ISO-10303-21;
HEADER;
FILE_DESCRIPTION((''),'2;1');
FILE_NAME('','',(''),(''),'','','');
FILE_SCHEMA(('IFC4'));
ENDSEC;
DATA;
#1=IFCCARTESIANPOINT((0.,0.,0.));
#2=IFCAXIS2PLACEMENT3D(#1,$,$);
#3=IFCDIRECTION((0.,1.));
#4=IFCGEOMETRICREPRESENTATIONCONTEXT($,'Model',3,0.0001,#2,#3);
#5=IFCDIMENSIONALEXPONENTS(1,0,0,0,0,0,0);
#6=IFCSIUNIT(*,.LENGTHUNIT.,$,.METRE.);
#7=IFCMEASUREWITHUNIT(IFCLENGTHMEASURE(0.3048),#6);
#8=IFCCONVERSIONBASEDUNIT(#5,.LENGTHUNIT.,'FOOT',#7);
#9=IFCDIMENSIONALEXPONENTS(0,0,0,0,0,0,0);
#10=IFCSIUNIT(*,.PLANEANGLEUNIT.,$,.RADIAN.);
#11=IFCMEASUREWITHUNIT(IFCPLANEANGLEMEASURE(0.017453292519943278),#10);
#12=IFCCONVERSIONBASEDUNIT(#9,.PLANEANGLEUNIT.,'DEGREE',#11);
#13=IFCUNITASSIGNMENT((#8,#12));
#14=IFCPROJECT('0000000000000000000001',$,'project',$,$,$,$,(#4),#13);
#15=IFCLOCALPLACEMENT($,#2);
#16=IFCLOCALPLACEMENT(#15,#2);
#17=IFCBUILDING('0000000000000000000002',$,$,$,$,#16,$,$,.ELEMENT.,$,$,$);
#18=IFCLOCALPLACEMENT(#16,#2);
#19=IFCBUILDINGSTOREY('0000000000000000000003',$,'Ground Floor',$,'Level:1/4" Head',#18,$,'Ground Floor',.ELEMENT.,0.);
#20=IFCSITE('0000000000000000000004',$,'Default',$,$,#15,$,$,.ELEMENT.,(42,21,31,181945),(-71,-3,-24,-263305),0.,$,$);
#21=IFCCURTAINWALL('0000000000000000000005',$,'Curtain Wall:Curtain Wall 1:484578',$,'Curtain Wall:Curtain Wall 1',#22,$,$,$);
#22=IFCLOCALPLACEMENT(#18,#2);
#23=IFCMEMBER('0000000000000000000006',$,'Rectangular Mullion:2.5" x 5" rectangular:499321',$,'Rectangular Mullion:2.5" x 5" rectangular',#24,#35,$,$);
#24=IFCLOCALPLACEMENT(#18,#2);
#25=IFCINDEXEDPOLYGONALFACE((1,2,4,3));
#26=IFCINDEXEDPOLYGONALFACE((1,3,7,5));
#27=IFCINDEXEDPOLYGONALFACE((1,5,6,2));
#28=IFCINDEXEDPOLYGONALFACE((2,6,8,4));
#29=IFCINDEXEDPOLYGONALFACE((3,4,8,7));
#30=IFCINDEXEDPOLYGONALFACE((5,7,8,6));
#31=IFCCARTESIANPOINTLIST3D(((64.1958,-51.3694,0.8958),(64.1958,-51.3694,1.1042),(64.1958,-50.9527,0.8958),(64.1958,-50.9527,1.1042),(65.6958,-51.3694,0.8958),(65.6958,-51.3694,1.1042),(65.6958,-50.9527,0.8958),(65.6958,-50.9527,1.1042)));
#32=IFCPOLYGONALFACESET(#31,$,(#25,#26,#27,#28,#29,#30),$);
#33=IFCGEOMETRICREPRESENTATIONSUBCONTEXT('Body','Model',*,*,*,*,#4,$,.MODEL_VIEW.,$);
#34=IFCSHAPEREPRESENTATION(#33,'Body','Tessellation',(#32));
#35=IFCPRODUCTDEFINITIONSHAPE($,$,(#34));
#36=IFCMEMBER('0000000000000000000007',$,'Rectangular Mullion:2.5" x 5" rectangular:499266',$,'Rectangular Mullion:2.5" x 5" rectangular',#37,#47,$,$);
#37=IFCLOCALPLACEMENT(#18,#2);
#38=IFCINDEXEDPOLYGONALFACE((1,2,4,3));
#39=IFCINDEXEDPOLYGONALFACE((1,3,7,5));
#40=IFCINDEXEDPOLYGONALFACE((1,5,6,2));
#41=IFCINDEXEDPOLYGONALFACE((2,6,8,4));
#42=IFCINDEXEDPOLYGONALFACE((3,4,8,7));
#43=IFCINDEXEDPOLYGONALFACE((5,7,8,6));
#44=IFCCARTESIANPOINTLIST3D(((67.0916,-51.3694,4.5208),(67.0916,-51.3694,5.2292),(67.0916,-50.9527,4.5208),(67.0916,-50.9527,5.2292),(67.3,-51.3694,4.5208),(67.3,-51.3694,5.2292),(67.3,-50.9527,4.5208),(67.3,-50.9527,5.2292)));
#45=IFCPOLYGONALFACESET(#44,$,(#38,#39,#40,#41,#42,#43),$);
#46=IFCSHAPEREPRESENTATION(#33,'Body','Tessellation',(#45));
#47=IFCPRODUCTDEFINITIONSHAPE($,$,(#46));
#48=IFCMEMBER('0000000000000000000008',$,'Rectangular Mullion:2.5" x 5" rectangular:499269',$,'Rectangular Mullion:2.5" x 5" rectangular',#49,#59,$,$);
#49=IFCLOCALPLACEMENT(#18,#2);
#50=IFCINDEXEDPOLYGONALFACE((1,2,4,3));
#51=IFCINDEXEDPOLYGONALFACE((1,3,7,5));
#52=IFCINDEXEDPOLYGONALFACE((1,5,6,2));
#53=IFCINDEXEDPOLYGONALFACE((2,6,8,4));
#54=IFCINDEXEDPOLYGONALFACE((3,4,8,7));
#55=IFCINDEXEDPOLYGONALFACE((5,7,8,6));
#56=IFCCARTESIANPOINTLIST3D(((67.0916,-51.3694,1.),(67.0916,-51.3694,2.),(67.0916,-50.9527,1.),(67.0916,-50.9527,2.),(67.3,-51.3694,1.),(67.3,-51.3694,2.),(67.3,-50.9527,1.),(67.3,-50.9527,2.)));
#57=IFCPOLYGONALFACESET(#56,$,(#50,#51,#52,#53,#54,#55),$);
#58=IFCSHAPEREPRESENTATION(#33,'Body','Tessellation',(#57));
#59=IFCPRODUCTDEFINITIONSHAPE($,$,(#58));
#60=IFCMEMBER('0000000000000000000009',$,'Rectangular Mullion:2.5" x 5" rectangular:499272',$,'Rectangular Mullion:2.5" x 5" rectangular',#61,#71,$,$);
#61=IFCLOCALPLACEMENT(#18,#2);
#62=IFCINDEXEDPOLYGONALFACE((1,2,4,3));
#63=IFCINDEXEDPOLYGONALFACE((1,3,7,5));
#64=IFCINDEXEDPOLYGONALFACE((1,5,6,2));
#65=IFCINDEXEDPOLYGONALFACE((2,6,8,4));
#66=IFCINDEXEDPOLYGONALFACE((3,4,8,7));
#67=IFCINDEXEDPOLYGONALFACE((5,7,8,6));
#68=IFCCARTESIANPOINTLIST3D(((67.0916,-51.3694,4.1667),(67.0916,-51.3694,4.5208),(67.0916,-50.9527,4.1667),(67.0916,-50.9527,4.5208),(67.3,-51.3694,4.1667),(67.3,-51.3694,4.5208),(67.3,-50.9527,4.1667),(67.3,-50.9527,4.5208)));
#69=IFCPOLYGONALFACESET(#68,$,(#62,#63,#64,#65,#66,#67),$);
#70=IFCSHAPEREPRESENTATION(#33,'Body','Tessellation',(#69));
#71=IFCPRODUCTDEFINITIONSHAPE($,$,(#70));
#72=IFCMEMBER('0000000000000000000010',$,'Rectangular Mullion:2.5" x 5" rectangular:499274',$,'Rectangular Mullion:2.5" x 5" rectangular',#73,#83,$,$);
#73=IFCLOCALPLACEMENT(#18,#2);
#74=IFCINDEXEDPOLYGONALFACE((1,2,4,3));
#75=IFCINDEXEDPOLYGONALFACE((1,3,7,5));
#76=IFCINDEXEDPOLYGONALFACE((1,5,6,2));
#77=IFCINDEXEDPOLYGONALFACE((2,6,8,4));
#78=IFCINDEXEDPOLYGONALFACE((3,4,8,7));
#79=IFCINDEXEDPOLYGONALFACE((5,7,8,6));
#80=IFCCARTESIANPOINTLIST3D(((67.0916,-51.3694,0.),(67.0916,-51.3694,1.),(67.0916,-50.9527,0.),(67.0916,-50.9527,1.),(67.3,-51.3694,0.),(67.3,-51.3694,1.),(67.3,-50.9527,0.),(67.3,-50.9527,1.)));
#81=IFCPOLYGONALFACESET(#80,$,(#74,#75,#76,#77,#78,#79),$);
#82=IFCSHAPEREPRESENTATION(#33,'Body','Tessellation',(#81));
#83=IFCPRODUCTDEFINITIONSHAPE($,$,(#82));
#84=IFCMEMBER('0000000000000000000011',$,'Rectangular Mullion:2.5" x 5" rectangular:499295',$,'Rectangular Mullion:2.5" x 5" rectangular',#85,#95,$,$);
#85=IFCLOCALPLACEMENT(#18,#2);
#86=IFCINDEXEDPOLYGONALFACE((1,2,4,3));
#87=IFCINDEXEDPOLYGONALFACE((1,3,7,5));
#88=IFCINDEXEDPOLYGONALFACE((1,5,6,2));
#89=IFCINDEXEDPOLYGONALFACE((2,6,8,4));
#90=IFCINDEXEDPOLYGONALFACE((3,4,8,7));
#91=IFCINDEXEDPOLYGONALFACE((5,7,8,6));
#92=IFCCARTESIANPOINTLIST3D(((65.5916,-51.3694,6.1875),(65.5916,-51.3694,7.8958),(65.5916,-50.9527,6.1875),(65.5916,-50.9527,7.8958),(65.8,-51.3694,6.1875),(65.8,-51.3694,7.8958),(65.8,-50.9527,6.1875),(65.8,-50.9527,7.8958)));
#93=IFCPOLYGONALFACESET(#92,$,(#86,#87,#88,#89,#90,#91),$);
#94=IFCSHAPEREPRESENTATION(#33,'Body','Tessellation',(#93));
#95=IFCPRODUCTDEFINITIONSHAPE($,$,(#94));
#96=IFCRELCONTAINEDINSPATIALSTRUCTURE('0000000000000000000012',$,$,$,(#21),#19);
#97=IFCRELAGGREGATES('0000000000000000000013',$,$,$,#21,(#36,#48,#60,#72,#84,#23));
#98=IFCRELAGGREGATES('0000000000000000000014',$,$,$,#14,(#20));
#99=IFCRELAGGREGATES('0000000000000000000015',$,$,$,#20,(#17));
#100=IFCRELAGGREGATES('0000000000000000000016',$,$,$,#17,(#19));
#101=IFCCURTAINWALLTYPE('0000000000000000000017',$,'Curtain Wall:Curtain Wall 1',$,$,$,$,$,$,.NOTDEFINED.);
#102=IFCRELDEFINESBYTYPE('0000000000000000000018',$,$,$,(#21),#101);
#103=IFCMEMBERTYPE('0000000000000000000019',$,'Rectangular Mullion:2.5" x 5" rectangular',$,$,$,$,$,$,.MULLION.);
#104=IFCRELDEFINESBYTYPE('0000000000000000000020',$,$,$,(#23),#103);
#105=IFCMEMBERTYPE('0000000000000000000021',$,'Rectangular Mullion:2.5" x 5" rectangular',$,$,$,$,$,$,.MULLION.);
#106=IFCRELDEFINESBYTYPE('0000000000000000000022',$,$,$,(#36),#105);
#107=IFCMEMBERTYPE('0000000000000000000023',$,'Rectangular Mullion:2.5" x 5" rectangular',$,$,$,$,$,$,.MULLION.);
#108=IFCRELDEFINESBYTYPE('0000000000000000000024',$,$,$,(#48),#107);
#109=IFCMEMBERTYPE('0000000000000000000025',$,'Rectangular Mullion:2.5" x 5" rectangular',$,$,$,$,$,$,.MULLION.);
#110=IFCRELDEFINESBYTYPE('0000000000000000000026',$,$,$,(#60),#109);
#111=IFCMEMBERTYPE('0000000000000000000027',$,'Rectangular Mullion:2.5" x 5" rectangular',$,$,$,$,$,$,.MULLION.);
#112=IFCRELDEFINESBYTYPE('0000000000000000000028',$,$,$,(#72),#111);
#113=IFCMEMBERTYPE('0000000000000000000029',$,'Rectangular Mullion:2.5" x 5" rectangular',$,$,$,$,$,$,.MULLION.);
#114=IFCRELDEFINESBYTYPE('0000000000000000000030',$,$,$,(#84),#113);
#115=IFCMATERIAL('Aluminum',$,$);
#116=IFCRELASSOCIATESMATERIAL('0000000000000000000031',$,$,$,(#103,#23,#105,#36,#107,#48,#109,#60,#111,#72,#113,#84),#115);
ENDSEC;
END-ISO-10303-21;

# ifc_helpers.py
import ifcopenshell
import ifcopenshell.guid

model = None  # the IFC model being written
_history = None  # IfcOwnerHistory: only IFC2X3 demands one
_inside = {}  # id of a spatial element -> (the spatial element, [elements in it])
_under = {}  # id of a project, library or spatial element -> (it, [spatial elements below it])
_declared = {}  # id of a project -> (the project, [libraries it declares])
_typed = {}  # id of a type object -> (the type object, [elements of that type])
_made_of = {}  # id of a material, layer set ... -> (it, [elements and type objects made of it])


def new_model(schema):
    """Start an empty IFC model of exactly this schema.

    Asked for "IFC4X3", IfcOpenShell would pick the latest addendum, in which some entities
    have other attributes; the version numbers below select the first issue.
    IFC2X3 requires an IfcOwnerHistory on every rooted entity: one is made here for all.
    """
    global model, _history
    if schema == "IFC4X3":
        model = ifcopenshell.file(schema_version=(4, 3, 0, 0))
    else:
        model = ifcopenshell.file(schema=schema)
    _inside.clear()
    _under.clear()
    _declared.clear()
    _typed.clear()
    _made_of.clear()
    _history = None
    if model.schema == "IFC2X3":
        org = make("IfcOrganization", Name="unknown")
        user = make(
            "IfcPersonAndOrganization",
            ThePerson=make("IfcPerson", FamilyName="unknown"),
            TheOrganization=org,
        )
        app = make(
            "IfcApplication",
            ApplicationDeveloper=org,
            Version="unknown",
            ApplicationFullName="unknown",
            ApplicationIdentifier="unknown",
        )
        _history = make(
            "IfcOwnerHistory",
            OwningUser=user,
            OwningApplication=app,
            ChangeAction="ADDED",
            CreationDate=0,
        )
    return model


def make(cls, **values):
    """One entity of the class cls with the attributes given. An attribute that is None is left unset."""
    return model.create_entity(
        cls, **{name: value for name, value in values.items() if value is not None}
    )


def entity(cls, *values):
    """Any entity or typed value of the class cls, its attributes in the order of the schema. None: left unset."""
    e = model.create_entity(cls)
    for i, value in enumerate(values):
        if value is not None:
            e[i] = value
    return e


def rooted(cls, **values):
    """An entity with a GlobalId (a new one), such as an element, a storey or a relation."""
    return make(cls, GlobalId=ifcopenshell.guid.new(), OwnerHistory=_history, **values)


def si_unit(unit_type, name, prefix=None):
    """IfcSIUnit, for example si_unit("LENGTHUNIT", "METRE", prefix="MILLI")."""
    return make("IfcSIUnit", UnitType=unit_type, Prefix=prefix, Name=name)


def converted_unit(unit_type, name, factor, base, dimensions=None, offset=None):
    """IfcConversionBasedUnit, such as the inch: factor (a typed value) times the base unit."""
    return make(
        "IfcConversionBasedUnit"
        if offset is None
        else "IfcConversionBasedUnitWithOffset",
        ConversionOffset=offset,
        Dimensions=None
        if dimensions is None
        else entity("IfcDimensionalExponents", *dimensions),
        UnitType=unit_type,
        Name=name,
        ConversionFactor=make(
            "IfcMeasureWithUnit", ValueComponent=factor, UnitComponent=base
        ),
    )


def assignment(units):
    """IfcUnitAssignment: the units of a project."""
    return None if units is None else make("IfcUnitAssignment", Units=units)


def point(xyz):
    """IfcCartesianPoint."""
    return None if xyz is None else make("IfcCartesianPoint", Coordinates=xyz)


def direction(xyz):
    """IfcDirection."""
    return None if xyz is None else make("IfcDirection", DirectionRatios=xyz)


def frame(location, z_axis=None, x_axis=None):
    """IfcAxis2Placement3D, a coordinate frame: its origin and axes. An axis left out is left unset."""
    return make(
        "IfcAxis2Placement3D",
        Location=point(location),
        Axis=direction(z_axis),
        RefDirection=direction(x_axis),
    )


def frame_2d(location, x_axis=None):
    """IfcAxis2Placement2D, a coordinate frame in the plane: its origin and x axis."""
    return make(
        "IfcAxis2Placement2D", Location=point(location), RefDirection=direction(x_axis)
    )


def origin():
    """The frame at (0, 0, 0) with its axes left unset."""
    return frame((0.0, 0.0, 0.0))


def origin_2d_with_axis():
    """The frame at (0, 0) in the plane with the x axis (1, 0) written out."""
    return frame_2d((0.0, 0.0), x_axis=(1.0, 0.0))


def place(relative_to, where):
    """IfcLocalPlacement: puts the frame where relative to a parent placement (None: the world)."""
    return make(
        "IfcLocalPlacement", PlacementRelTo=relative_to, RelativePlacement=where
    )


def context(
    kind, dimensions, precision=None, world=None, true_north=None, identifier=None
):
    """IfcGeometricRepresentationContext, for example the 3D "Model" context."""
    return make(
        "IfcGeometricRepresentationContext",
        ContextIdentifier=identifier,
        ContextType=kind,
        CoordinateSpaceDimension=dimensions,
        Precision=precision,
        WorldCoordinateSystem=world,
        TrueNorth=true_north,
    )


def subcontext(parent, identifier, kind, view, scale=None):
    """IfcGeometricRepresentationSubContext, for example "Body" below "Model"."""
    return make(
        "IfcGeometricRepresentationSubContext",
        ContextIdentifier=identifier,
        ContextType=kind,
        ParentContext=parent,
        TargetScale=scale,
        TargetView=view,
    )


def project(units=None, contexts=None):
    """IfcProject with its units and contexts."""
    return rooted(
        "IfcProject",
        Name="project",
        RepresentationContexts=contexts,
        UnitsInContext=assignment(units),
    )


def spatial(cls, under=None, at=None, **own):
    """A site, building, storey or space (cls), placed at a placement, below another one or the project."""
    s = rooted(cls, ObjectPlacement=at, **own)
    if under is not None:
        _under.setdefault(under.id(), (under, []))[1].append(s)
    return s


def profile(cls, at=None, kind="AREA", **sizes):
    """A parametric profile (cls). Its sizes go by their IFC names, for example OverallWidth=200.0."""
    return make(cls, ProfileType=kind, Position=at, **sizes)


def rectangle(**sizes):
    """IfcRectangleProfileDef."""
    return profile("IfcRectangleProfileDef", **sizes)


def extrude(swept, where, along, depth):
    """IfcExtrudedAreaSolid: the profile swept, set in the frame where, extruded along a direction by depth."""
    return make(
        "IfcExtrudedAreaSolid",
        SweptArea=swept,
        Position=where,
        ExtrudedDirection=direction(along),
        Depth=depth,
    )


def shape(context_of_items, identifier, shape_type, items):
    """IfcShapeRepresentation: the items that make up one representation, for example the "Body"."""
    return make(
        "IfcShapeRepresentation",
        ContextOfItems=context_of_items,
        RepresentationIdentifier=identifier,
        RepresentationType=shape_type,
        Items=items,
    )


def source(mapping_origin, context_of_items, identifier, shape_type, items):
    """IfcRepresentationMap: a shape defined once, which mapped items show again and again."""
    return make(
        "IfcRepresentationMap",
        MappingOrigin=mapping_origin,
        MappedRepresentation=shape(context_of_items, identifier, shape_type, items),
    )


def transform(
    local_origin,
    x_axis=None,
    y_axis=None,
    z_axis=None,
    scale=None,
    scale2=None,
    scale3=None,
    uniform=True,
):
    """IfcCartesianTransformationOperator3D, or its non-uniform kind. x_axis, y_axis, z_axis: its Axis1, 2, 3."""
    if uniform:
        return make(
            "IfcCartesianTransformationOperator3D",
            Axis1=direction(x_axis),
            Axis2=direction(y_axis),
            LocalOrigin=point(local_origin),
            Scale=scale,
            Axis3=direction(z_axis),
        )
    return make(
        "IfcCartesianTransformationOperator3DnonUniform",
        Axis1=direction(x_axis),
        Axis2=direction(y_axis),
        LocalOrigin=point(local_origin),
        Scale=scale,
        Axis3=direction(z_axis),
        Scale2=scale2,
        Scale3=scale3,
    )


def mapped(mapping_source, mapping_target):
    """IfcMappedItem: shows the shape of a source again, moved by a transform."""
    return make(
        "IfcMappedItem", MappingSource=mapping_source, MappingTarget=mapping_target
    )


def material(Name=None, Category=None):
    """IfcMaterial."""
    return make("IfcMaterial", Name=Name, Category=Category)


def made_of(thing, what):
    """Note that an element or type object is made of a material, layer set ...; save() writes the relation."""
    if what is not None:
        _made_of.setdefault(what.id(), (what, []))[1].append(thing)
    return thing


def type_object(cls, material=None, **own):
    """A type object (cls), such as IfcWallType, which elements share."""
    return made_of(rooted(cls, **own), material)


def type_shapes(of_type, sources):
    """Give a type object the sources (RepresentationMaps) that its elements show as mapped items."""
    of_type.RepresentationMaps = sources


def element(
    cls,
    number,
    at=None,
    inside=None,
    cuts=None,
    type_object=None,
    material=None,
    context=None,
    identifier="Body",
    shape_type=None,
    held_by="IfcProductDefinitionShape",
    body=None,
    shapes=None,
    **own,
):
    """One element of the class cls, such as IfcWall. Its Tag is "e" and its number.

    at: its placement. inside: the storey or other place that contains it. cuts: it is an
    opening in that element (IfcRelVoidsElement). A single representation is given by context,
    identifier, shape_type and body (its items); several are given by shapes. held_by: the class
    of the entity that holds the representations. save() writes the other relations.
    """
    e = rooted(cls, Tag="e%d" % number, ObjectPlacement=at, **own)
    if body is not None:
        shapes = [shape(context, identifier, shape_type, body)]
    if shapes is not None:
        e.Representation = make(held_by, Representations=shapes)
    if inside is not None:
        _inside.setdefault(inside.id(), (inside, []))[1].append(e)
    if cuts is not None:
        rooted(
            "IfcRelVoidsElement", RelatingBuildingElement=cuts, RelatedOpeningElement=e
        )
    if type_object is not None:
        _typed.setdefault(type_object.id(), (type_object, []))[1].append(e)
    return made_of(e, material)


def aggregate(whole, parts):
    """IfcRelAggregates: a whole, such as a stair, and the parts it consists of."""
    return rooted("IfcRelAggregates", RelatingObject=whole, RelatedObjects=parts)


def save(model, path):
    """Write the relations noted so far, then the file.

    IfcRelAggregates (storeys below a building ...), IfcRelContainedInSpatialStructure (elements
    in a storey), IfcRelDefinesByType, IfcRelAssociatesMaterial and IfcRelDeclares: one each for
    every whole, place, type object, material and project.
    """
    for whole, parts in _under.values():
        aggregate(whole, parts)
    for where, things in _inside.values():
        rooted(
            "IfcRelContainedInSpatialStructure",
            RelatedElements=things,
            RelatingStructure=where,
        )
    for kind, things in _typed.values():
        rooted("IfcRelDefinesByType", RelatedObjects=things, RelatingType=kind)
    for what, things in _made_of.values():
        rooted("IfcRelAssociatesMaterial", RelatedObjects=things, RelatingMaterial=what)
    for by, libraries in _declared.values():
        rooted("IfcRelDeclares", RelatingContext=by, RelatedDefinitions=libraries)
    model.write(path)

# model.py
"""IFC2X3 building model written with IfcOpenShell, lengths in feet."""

from ifc_helpers import new_model, entity, si_unit, converted_unit, direction, frame, origin, origin_2d_with_axis, place, context, subcontext, project, spatial, rectangle, extrude, source, transform, mapped, material, type_object, type_shapes, element, aggregate, save


model = new_model("IFC2X3")

# Units and contexts
model_context = context("Model", 3, precision=0.0001, world=origin(), true_north=direction((0.0, 1.0)))
body_context = subcontext(model_context, "Body", "Model", "MODEL_VIEW")
ifc_project = project(units=[converted_unit("LENGTHUNIT", "FOOT", entity("IfcLengthMeasure", 0.3048), si_unit("LENGTHUNIT", "METRE"), dimensions=[1, 0, 0, 0, 0, 0, 0]), converted_unit("PLANEANGLEUNIT", "DEGREE", entity("IfcPlaneAngleMeasure", 0.017453292519943278), si_unit("PLANEANGLEUNIT", "RADIAN"), dimensions=[0, 0, 0, 0, 0, 0, 0])], contexts=[model_context])

# Site, building, storey
site_placement = place(None, origin())
site = spatial("IfcSite", under=ifc_project, at=site_placement, Name="Default", CompositionType="ELEMENT", RefLatitude=(42, 21, 31, 181945), RefLongitude=(-71, -3, -24, -263305), RefElevation=0.0)
building_placement = place(site_placement, origin())
building = spatial("IfcBuilding", under=site, at=building_placement, CompositionType="ELEMENT")
storey_placement = place(building_placement, origin())
storey = spatial("IfcBuildingStorey", under=building, at=storey_placement, Name="Ground Floor", ObjectType="Level:1/4\" Head", LongName="Ground Floor", CompositionType="ELEMENT", Elevation=0.0)

# Curtain wall, members
curtain_wall_type = type_object("IfcCurtainWallType", Name="Curtain Wall:Curtain Wall 1", PredefinedType="NOTDEFINED")
curtain_wall_placement = place(storey_placement, origin())
curtain_wall = element("IfcCurtainWall", 1, at=curtain_wall_placement, inside=storey, type_object=curtain_wall_type, Name="Curtain Wall:Curtain Wall 1:484578", ObjectType="Curtain Wall:Curtain Wall 1")
ifc_material_1 = material(Name="Aluminum")
member_type_1 = type_object("IfcMemberType", Name="Rectangular Mullion:2.5\" x 5\" rectangular", PredefinedType="MULLION", material=ifc_material_1)
shared_shape_1 = source(origin(), body_context, "Body", "SweptSolid", [
    extrude(rectangle(XDim=0.2083, YDim=0.4167, at=origin_2d_with_axis()), frame((0.0, 0.0, -1.5), z_axis=(0.0, 0.0, 1.0), x_axis=(-1.0, 0.0, 0.0)), (0.0, 0.0, 1.0), 1.5),
])
type_shapes(member_type_1, [shared_shape_1])
member_1_placement = place(curtain_wall_placement, frame((65.6958, -51.161, 1.0), z_axis=(1.0, 0.0, 0.0), x_axis=(0.0, 0.0, 1.0)))
member_1 = element("IfcMember", 2, at=member_1_placement, type_object=member_type_1, material=ifc_material_1, Name="Rectangular Mullion:2.5\" x 5\" rectangular:499321", ObjectType="Rectangular Mullion:2.5\" x 5\" rectangular", context=body_context, shape_type="MappedRepresentation", body=[
    mapped(shared_shape_1, transform((0.0, 0.0, 0.0), scale=1.0)),
])
member_type_2 = type_object("IfcMemberType", Name="Rectangular Mullion:2.5\" x 5\" rectangular", PredefinedType="MULLION", material=ifc_material_1)
shared_shape_2 = source(origin(), body_context, "Body", "SweptSolid", [
    extrude(rectangle(XDim=0.2083, YDim=0.4167, at=origin_2d_with_axis()), frame((0.0, 0.0, -0.7083), z_axis=(0.0, 0.0, 1.0), x_axis=(-1.0, 0.0, 0.0)), (0.0, 0.0, 1.0), 0.7083),
])
type_shapes(member_type_2, [shared_shape_2])
member_2_placement = place(curtain_wall_placement, frame((67.1958, -51.161, 4.5208), z_axis=(0.0, 0.0, -1.0), x_axis=(1.0, 0.0, 0.0)))
member_2 = element("IfcMember", 3, at=member_2_placement, type_object=member_type_2, material=ifc_material_1, Name="Rectangular Mullion:2.5\" x 5\" rectangular:499266", ObjectType="Rectangular Mullion:2.5\" x 5\" rectangular", context=body_context, shape_type="MappedRepresentation", body=[
    mapped(shared_shape_2, transform((0.0, 0.0, 0.0), scale=1.0)),
])
member_type_3 = type_object("IfcMemberType", Name="Rectangular Mullion:2.5\" x 5\" rectangular", PredefinedType="MULLION", material=ifc_material_1)
shared_shape_3 = source(origin(), body_context, "Body", "SweptSolid", [
    extrude(rectangle(XDim=0.2083, YDim=0.4167, at=origin_2d_with_axis()), frame((0.0, 0.0, -1.0), z_axis=(0.0, 0.0, 1.0), x_axis=(-1.0, 0.0, 0.0)), (0.0, 0.0, 1.0), 1.0),
])
type_shapes(member_type_3, [shared_shape_3])
member_3_placement = place(curtain_wall_placement, frame((67.1958, -51.161, 1.0), z_axis=(0.0, 0.0, -1.0), x_axis=(1.0, 0.0, 0.0)))
member_3 = element("IfcMember", 4, at=member_3_placement, type_object=member_type_3, material=ifc_material_1, Name="Rectangular Mullion:2.5\" x 5\" rectangular:499269", ObjectType="Rectangular Mullion:2.5\" x 5\" rectangular", context=body_context, shape_type="MappedRepresentation", body=[
    mapped(shared_shape_3, transform((0.0, 0.0, 0.0), scale=1.0)),
])
member_type_4 = type_object("IfcMemberType", Name="Rectangular Mullion:2.5\" x 5\" rectangular", PredefinedType="MULLION", material=ifc_material_1)
shared_shape_4 = source(origin(), body_context, "Body", "SweptSolid", [
    extrude(rectangle(XDim=0.2083, YDim=0.4167, at=origin_2d_with_axis()), frame((0.0, 0.0, -0.3542), z_axis=(0.0, 0.0, 1.0), x_axis=(-1.0, 0.0, 0.0)), (0.0, 0.0, 1.0), 0.3542),
])
type_shapes(member_type_4, [shared_shape_4])
member_4_placement = place(curtain_wall_placement, frame((67.1958, -51.161, 4.1667), z_axis=(0.0, 0.0, -1.0), x_axis=(1.0, 0.0, 0.0)))
member_4 = element("IfcMember", 5, at=member_4_placement, type_object=member_type_4, material=ifc_material_1, Name="Rectangular Mullion:2.5\" x 5\" rectangular:499272", ObjectType="Rectangular Mullion:2.5\" x 5\" rectangular", context=body_context, shape_type="MappedRepresentation", body=[
    mapped(shared_shape_4, transform((0.0, 0.0, 0.0), scale=1.0)),
])
member_type_5 = type_object("IfcMemberType", Name="Rectangular Mullion:2.5\" x 5\" rectangular", PredefinedType="MULLION", material=ifc_material_1)
shared_shape_5 = source(origin(), body_context, "Body", "SweptSolid", [
    extrude(rectangle(XDim=0.2083, YDim=0.4167, at=origin_2d_with_axis()), frame((0.0, 0.0, -1.0), z_axis=(0.0, 0.0, 1.0), x_axis=(-1.0, 0.0, 0.0)), (0.0, 0.0, 1.0), 1.0),
])
type_shapes(member_type_5, [shared_shape_5])
member_5_placement = place(curtain_wall_placement, frame((67.1958, -51.161, 0.0), z_axis=(0.0, 0.0, -1.0), x_axis=(1.0, 0.0, 0.0)))
member_5 = element("IfcMember", 6, at=member_5_placement, type_object=member_type_5, material=ifc_material_1, Name="Rectangular Mullion:2.5\" x 5\" rectangular:499274", ObjectType="Rectangular Mullion:2.5\" x 5\" rectangular", context=body_context, shape_type="MappedRepresentation", body=[
    mapped(shared_shape_5, transform((0.0, 0.0, 0.0), scale=1.0)),
])
member_type_6 = type_object("IfcMemberType", Name="Rectangular Mullion:2.5\" x 5\" rectangular", PredefinedType="MULLION", material=ifc_material_1)
shared_shape_6 = source(origin(), body_context, "Body", "SweptSolid", [
    extrude(rectangle(XDim=0.2083, YDim=0.4167, at=origin_2d_with_axis()), frame((0.0, 0.0, -1.7083), z_axis=(0.0, 0.0, 1.0), x_axis=(-1.0, 0.0, 0.0)), (0.0, 0.0, 1.0), 1.7083),
])
type_shapes(member_type_6, [shared_shape_6])
member_6_placement = place(curtain_wall_placement, frame((65.6958, -51.161, 6.1875), z_axis=(0.0, 0.0, -1.0), x_axis=(1.0, 0.0, 0.0)))
member_6 = element("IfcMember", 7, at=member_6_placement, type_object=member_type_6, material=ifc_material_1, Name="Rectangular Mullion:2.5\" x 5\" rectangular:499295", ObjectType="Rectangular Mullion:2.5\" x 5\" rectangular", context=body_context, shape_type="MappedRepresentation", body=[
    mapped(shared_shape_6, transform((0.0, 0.0, 0.0), scale=1.0)),
])
aggregate(curtain_wall, [member_2, member_3, member_4, member_5, member_6, member_1])

save(model, "model.ifc")
